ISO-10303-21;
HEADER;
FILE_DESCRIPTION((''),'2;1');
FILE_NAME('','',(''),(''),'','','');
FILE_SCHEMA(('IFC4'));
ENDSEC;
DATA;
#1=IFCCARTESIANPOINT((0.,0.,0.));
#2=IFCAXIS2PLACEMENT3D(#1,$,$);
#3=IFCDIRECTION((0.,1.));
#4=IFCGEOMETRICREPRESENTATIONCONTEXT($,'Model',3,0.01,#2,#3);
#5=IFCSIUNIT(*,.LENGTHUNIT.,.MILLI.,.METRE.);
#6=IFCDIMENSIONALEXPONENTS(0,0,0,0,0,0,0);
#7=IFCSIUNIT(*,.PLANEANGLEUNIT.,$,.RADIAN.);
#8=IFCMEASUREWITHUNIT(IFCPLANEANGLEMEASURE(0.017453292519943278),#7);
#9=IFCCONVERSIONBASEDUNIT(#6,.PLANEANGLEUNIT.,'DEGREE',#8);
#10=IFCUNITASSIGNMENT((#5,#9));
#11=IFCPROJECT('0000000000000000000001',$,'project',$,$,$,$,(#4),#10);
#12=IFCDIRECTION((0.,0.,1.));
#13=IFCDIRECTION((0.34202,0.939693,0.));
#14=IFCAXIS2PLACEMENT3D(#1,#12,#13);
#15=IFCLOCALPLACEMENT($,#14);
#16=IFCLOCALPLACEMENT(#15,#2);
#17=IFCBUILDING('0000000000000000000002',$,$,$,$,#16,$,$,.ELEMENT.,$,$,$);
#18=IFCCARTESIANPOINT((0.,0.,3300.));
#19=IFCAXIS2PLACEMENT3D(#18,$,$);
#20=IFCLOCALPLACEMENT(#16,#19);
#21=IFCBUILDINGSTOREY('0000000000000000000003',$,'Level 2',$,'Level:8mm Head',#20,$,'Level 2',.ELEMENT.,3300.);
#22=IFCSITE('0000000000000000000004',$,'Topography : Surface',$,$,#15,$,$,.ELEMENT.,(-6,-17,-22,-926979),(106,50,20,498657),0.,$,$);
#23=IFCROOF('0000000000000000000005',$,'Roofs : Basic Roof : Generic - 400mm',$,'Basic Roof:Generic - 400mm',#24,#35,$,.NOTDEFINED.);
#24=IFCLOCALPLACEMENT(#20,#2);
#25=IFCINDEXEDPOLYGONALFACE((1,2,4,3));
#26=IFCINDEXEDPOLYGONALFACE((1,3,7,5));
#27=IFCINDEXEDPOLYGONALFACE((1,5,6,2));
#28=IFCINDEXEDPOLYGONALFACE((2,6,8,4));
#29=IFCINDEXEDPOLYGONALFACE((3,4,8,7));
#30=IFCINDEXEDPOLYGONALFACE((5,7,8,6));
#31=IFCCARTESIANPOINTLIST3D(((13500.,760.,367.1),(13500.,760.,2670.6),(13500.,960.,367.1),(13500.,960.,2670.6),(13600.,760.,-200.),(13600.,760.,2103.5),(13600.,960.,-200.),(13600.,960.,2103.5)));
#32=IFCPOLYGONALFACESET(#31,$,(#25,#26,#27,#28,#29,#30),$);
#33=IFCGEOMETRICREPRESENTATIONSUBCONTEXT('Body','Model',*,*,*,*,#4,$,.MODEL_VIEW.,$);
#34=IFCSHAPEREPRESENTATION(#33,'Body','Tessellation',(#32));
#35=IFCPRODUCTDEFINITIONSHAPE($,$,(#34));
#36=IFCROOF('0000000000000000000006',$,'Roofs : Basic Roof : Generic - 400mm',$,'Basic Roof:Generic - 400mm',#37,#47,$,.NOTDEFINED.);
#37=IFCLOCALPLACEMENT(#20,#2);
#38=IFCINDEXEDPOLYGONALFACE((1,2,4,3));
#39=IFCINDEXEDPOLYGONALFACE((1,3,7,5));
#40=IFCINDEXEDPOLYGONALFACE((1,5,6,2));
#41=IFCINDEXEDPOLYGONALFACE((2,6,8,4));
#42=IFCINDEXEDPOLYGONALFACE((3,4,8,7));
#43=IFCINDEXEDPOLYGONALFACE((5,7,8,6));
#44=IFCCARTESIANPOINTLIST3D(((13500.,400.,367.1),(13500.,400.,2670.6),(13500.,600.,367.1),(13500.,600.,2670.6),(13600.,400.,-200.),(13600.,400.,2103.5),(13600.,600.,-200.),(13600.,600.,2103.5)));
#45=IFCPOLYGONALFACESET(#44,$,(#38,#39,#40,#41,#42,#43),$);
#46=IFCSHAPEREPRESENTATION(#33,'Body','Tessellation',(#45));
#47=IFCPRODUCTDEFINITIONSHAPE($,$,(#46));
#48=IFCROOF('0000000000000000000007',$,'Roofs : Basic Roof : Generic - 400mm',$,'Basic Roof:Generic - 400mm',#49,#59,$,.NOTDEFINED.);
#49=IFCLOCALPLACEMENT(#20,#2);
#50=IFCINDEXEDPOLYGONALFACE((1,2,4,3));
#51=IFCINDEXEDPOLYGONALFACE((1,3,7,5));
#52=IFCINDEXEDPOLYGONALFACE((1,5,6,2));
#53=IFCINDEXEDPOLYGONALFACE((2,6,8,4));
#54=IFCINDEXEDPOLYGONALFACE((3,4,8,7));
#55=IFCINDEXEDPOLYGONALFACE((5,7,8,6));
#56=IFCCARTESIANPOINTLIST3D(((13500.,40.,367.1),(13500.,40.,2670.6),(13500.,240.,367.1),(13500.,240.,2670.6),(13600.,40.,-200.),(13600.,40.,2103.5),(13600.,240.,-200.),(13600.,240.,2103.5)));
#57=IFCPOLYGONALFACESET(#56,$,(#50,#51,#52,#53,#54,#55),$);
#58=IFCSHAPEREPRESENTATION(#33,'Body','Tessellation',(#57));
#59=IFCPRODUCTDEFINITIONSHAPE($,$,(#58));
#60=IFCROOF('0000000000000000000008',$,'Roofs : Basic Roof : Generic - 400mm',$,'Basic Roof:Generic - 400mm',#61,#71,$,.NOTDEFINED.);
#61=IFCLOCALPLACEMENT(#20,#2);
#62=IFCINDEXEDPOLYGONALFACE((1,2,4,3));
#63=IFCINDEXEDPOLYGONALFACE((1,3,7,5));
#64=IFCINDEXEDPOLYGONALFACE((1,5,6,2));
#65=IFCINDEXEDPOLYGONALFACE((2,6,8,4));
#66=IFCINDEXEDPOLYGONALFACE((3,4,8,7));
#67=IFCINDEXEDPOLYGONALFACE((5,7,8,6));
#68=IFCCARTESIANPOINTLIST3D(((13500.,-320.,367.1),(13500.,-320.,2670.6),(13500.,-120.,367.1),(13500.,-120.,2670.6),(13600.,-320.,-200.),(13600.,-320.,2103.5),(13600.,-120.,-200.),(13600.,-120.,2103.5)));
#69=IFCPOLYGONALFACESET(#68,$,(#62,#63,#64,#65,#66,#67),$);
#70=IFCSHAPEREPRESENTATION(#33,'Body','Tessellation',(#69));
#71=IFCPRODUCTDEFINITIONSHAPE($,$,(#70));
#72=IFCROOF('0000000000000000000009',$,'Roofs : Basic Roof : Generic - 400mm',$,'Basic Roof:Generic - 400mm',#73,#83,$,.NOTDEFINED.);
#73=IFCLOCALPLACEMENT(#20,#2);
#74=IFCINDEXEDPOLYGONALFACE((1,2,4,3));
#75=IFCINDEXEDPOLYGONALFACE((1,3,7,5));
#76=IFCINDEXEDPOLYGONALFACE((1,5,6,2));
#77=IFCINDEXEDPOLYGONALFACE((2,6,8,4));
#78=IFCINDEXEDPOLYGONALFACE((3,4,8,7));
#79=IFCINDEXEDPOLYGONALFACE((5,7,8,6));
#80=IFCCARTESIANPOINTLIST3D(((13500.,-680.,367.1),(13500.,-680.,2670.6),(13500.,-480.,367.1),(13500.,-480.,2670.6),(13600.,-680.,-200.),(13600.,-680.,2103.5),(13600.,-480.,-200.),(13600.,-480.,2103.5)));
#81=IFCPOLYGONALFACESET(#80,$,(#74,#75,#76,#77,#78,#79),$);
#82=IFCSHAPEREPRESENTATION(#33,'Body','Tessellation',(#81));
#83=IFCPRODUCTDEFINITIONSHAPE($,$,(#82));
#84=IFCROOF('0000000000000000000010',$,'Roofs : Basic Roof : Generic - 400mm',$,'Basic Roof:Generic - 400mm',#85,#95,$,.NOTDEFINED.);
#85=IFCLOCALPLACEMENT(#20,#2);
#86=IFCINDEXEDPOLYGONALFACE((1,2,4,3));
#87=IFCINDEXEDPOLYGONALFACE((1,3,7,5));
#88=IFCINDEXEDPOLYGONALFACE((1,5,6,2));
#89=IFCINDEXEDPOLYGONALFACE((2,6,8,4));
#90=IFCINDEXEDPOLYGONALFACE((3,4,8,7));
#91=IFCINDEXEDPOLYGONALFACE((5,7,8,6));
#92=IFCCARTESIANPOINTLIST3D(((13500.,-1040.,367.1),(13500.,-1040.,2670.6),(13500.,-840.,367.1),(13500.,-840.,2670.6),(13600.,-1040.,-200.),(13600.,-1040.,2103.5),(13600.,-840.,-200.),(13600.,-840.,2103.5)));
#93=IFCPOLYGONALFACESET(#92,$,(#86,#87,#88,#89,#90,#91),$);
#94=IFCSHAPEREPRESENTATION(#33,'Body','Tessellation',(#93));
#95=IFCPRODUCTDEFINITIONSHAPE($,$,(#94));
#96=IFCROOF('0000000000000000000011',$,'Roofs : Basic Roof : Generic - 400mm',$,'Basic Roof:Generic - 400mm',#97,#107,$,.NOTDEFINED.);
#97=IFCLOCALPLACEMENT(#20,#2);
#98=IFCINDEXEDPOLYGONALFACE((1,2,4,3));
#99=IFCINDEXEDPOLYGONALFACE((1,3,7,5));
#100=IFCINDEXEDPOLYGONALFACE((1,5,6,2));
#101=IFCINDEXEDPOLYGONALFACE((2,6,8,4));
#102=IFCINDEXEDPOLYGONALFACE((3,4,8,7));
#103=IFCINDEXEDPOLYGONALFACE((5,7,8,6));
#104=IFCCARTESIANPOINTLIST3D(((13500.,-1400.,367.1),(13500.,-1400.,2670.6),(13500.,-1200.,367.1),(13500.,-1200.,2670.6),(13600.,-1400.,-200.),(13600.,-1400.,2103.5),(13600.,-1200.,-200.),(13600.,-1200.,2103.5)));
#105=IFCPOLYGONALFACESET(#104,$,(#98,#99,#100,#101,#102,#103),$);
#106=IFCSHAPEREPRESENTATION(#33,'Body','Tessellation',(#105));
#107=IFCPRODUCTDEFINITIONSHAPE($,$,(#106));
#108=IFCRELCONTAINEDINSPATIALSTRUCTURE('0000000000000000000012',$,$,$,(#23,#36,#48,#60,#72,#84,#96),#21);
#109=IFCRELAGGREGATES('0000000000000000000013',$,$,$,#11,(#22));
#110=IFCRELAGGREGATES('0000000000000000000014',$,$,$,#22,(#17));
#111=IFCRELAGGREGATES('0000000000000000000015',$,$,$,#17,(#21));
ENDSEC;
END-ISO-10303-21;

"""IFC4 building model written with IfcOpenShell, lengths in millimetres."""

from ifc_helpers import new_model, entity, si_unit, converted_unit, direction, frame, origin, place, context, subcontext, project, spatial, indexed_curve, outline, extrude, element, save


model = new_model("IFC4")

# Units and contexts
model_context = context("Model", 3, precision=0.01, world=origin(), true_north=direction((0.0, 1.0)))
body_context = subcontext(model_context, "Body", "Model", "MODEL_VIEW")
ifc_project = project(units=[si_unit("LENGTHUNIT", "METRE", prefix="MILLI"), converted_unit("PLANEANGLEUNIT", "DEGREE", entity("IfcPlaneAngleMeasure", 0.017453292519943278), si_unit("PLANEANGLEUNIT", "RADIAN"), dimensions=[0, 0, 0, 0, 0, 0, 0])], contexts=[model_context])

# Site, building, storey
site_placement = place(None, frame((0.0, 0.0, 0.0), z_axis=(0.0, 0.0, 1.0), x_axis=(0.34202, 0.939693, 0.0)))
site = spatial("IfcSite", under=ifc_project, at=site_placement, Name="Topography : Surface", CompositionType="ELEMENT", RefLatitude=(-6, -17, -22, -926979), RefLongitude=(106, 50, 20, 498657), RefElevation=0.0)
building_placement = place(site_placement, origin())
building = spatial("IfcBuilding", under=site, at=building_placement, CompositionType="ELEMENT")
storey_placement = place(building_placement, frame((0.0, 0.0, 3300.0)))
storey = spatial("IfcBuildingStorey", under=building, at=storey_placement, Name="Level 2", ObjectType="Level:8mm Head", LongName="Level 2", CompositionType="ELEMENT", Elevation=3300.0)

# Roofs
roof_1_placement = place(storey_placement, frame((13500.0, 760.0, -200.0)))
element("IfcRoof", 1, at=roof_1_placement, inside=storey, Name="Roofs : Basic Roof : Generic - 400mm", ObjectType="Basic Roof:Generic - 400mm", PredefinedType="NOTDEFINED", context=body_context, shape_type="SweptSolid", body=[
    extrude(outline(indexed_curve([(-287.9, 100.0), (-287.9, -100.0), (287.9, -100.0), (287.9, 100.0), (-287.9, 100.0)], self_intersect=False)), frame((50.0, 100.0, 283.6), z_axis=(0.984808, 0.0, 0.173648), x_axis=(0.173648, 0.0, -0.984808)), (-0.984808, 0.0, 0.173648), 2303.5),
])
roof_2_placement = place(storey_placement, frame((13500.0, 400.0, -200.0)))
element("IfcRoof", 2, at=roof_2_placement, inside=storey, Name="Roofs : Basic Roof : Generic - 400mm", ObjectType="Basic Roof:Generic - 400mm", PredefinedType="NOTDEFINED", context=body_context, shape_type="SweptSolid", body=[
    extrude(outline(indexed_curve([(-287.9, 100.0), (-287.9, -100.0), (287.9, -100.0), (287.9, 100.0), (-287.9, 100.0)], self_intersect=False)), frame((50.0, 100.0, 283.6), z_axis=(0.984808, 0.0, 0.173648), x_axis=(0.173648, 0.0, -0.984808)), (-0.984808, 0.0, 0.173648), 2303.5),
])
roof_3_placement = place(storey_placement, frame((13500.0, 40.0, -200.0)))
element("IfcRoof", 3, at=roof_3_placement, inside=storey, Name="Roofs : Basic Roof : Generic - 400mm", ObjectType="Basic Roof:Generic - 400mm", PredefinedType="NOTDEFINED", context=body_context, shape_type="SweptSolid", body=[
    extrude(outline(indexed_curve([(-287.9, 100.0), (-287.9, -100.0), (287.9, -100.0), (287.9, 100.0), (-287.9, 100.0)], self_intersect=False)), frame((50.0, 100.0, 283.6), z_axis=(0.984808, 0.0, 0.173648), x_axis=(0.173648, 0.0, -0.984808)), (-0.984808, 0.0, 0.173648), 2303.5),
])
roof_4_placement = place(storey_placement, frame((13500.0, -320.0, -200.0)))
element("IfcRoof", 4, at=roof_4_placement, inside=storey, Name="Roofs : Basic Roof : Generic - 400mm", ObjectType="Basic Roof:Generic - 400mm", PredefinedType="NOTDEFINED", context=body_context, shape_type="SweptSolid", body=[
    extrude(outline(indexed_curve([(-287.9, 100.0), (-287.9, -100.0), (287.9, -100.0), (287.9, 100.0), (-287.9, 100.0)], self_intersect=False)), frame((50.0, 100.0, 283.6), z_axis=(0.984808, 0.0, 0.173648), x_axis=(0.173648, 0.0, -0.984808)), (-0.984808, 0.0, 0.173648), 2303.5),
])
roof_5_placement = place(storey_placement, frame((13500.0, -680.0, -200.0)))
element("IfcRoof", 5, at=roof_5_placement, inside=storey, Name="Roofs : Basic Roof : Generic - 400mm", ObjectType="Basic Roof:Generic - 400mm", PredefinedType="NOTDEFINED", context=body_context, shape_type="SweptSolid", body=[
    extrude(outline(indexed_curve([(-287.9, 100.0), (-287.9, -100.0), (287.9, -100.0), (287.9, 100.0), (-287.9, 100.0)], self_intersect=False)), frame((50.0, 100.0, 283.6), z_axis=(0.984808, 0.0, 0.173648), x_axis=(0.173648, 0.0, -0.984808)), (-0.984808, 0.0, 0.173648), 2303.5),
])
roof_6_placement = place(storey_placement, frame((13500.0, -1040.0, -200.0)))
element("IfcRoof", 6, at=roof_6_placement, inside=storey, Name="Roofs : Basic Roof : Generic - 400mm", ObjectType="Basic Roof:Generic - 400mm", PredefinedType="NOTDEFINED", context=body_context, shape_type="SweptSolid", body=[
    extrude(outline(indexed_curve([(-287.9, 100.0), (-287.9, -100.0), (287.9, -100.0), (287.9, 100.0), (-287.9, 100.0)], self_intersect=False)), frame((50.0, 100.0, 283.6), z_axis=(0.984808, 0.0, 0.173648), x_axis=(0.173648, 0.0, -0.984808)), (-0.984808, 0.0, 0.173648), 2303.5),
])
roof_7_placement = place(storey_placement, frame((13500.0, -1400.0, -200.0)))
element("IfcRoof", 7, at=roof_7_placement, inside=storey, Name="Roofs : Basic Roof : Generic - 400mm", ObjectType="Basic Roof:Generic - 400mm", PredefinedType="NOTDEFINED", context=body_context, shape_type="SweptSolid", body=[
    extrude(outline(indexed_curve([(-287.9, 100.0), (-287.9, -100.0), (287.9, -100.0), (287.9, 100.0), (-287.9, 100.0)], self_intersect=False)), frame((50.0, 100.0, 283.6), z_axis=(0.984808, 0.0, 0.173648), x_axis=(0.173648, 0.0, -0.984808)), (-0.984808, 0.0, 0.173648), 2303.5),
])

save(model, "model.ifc")
